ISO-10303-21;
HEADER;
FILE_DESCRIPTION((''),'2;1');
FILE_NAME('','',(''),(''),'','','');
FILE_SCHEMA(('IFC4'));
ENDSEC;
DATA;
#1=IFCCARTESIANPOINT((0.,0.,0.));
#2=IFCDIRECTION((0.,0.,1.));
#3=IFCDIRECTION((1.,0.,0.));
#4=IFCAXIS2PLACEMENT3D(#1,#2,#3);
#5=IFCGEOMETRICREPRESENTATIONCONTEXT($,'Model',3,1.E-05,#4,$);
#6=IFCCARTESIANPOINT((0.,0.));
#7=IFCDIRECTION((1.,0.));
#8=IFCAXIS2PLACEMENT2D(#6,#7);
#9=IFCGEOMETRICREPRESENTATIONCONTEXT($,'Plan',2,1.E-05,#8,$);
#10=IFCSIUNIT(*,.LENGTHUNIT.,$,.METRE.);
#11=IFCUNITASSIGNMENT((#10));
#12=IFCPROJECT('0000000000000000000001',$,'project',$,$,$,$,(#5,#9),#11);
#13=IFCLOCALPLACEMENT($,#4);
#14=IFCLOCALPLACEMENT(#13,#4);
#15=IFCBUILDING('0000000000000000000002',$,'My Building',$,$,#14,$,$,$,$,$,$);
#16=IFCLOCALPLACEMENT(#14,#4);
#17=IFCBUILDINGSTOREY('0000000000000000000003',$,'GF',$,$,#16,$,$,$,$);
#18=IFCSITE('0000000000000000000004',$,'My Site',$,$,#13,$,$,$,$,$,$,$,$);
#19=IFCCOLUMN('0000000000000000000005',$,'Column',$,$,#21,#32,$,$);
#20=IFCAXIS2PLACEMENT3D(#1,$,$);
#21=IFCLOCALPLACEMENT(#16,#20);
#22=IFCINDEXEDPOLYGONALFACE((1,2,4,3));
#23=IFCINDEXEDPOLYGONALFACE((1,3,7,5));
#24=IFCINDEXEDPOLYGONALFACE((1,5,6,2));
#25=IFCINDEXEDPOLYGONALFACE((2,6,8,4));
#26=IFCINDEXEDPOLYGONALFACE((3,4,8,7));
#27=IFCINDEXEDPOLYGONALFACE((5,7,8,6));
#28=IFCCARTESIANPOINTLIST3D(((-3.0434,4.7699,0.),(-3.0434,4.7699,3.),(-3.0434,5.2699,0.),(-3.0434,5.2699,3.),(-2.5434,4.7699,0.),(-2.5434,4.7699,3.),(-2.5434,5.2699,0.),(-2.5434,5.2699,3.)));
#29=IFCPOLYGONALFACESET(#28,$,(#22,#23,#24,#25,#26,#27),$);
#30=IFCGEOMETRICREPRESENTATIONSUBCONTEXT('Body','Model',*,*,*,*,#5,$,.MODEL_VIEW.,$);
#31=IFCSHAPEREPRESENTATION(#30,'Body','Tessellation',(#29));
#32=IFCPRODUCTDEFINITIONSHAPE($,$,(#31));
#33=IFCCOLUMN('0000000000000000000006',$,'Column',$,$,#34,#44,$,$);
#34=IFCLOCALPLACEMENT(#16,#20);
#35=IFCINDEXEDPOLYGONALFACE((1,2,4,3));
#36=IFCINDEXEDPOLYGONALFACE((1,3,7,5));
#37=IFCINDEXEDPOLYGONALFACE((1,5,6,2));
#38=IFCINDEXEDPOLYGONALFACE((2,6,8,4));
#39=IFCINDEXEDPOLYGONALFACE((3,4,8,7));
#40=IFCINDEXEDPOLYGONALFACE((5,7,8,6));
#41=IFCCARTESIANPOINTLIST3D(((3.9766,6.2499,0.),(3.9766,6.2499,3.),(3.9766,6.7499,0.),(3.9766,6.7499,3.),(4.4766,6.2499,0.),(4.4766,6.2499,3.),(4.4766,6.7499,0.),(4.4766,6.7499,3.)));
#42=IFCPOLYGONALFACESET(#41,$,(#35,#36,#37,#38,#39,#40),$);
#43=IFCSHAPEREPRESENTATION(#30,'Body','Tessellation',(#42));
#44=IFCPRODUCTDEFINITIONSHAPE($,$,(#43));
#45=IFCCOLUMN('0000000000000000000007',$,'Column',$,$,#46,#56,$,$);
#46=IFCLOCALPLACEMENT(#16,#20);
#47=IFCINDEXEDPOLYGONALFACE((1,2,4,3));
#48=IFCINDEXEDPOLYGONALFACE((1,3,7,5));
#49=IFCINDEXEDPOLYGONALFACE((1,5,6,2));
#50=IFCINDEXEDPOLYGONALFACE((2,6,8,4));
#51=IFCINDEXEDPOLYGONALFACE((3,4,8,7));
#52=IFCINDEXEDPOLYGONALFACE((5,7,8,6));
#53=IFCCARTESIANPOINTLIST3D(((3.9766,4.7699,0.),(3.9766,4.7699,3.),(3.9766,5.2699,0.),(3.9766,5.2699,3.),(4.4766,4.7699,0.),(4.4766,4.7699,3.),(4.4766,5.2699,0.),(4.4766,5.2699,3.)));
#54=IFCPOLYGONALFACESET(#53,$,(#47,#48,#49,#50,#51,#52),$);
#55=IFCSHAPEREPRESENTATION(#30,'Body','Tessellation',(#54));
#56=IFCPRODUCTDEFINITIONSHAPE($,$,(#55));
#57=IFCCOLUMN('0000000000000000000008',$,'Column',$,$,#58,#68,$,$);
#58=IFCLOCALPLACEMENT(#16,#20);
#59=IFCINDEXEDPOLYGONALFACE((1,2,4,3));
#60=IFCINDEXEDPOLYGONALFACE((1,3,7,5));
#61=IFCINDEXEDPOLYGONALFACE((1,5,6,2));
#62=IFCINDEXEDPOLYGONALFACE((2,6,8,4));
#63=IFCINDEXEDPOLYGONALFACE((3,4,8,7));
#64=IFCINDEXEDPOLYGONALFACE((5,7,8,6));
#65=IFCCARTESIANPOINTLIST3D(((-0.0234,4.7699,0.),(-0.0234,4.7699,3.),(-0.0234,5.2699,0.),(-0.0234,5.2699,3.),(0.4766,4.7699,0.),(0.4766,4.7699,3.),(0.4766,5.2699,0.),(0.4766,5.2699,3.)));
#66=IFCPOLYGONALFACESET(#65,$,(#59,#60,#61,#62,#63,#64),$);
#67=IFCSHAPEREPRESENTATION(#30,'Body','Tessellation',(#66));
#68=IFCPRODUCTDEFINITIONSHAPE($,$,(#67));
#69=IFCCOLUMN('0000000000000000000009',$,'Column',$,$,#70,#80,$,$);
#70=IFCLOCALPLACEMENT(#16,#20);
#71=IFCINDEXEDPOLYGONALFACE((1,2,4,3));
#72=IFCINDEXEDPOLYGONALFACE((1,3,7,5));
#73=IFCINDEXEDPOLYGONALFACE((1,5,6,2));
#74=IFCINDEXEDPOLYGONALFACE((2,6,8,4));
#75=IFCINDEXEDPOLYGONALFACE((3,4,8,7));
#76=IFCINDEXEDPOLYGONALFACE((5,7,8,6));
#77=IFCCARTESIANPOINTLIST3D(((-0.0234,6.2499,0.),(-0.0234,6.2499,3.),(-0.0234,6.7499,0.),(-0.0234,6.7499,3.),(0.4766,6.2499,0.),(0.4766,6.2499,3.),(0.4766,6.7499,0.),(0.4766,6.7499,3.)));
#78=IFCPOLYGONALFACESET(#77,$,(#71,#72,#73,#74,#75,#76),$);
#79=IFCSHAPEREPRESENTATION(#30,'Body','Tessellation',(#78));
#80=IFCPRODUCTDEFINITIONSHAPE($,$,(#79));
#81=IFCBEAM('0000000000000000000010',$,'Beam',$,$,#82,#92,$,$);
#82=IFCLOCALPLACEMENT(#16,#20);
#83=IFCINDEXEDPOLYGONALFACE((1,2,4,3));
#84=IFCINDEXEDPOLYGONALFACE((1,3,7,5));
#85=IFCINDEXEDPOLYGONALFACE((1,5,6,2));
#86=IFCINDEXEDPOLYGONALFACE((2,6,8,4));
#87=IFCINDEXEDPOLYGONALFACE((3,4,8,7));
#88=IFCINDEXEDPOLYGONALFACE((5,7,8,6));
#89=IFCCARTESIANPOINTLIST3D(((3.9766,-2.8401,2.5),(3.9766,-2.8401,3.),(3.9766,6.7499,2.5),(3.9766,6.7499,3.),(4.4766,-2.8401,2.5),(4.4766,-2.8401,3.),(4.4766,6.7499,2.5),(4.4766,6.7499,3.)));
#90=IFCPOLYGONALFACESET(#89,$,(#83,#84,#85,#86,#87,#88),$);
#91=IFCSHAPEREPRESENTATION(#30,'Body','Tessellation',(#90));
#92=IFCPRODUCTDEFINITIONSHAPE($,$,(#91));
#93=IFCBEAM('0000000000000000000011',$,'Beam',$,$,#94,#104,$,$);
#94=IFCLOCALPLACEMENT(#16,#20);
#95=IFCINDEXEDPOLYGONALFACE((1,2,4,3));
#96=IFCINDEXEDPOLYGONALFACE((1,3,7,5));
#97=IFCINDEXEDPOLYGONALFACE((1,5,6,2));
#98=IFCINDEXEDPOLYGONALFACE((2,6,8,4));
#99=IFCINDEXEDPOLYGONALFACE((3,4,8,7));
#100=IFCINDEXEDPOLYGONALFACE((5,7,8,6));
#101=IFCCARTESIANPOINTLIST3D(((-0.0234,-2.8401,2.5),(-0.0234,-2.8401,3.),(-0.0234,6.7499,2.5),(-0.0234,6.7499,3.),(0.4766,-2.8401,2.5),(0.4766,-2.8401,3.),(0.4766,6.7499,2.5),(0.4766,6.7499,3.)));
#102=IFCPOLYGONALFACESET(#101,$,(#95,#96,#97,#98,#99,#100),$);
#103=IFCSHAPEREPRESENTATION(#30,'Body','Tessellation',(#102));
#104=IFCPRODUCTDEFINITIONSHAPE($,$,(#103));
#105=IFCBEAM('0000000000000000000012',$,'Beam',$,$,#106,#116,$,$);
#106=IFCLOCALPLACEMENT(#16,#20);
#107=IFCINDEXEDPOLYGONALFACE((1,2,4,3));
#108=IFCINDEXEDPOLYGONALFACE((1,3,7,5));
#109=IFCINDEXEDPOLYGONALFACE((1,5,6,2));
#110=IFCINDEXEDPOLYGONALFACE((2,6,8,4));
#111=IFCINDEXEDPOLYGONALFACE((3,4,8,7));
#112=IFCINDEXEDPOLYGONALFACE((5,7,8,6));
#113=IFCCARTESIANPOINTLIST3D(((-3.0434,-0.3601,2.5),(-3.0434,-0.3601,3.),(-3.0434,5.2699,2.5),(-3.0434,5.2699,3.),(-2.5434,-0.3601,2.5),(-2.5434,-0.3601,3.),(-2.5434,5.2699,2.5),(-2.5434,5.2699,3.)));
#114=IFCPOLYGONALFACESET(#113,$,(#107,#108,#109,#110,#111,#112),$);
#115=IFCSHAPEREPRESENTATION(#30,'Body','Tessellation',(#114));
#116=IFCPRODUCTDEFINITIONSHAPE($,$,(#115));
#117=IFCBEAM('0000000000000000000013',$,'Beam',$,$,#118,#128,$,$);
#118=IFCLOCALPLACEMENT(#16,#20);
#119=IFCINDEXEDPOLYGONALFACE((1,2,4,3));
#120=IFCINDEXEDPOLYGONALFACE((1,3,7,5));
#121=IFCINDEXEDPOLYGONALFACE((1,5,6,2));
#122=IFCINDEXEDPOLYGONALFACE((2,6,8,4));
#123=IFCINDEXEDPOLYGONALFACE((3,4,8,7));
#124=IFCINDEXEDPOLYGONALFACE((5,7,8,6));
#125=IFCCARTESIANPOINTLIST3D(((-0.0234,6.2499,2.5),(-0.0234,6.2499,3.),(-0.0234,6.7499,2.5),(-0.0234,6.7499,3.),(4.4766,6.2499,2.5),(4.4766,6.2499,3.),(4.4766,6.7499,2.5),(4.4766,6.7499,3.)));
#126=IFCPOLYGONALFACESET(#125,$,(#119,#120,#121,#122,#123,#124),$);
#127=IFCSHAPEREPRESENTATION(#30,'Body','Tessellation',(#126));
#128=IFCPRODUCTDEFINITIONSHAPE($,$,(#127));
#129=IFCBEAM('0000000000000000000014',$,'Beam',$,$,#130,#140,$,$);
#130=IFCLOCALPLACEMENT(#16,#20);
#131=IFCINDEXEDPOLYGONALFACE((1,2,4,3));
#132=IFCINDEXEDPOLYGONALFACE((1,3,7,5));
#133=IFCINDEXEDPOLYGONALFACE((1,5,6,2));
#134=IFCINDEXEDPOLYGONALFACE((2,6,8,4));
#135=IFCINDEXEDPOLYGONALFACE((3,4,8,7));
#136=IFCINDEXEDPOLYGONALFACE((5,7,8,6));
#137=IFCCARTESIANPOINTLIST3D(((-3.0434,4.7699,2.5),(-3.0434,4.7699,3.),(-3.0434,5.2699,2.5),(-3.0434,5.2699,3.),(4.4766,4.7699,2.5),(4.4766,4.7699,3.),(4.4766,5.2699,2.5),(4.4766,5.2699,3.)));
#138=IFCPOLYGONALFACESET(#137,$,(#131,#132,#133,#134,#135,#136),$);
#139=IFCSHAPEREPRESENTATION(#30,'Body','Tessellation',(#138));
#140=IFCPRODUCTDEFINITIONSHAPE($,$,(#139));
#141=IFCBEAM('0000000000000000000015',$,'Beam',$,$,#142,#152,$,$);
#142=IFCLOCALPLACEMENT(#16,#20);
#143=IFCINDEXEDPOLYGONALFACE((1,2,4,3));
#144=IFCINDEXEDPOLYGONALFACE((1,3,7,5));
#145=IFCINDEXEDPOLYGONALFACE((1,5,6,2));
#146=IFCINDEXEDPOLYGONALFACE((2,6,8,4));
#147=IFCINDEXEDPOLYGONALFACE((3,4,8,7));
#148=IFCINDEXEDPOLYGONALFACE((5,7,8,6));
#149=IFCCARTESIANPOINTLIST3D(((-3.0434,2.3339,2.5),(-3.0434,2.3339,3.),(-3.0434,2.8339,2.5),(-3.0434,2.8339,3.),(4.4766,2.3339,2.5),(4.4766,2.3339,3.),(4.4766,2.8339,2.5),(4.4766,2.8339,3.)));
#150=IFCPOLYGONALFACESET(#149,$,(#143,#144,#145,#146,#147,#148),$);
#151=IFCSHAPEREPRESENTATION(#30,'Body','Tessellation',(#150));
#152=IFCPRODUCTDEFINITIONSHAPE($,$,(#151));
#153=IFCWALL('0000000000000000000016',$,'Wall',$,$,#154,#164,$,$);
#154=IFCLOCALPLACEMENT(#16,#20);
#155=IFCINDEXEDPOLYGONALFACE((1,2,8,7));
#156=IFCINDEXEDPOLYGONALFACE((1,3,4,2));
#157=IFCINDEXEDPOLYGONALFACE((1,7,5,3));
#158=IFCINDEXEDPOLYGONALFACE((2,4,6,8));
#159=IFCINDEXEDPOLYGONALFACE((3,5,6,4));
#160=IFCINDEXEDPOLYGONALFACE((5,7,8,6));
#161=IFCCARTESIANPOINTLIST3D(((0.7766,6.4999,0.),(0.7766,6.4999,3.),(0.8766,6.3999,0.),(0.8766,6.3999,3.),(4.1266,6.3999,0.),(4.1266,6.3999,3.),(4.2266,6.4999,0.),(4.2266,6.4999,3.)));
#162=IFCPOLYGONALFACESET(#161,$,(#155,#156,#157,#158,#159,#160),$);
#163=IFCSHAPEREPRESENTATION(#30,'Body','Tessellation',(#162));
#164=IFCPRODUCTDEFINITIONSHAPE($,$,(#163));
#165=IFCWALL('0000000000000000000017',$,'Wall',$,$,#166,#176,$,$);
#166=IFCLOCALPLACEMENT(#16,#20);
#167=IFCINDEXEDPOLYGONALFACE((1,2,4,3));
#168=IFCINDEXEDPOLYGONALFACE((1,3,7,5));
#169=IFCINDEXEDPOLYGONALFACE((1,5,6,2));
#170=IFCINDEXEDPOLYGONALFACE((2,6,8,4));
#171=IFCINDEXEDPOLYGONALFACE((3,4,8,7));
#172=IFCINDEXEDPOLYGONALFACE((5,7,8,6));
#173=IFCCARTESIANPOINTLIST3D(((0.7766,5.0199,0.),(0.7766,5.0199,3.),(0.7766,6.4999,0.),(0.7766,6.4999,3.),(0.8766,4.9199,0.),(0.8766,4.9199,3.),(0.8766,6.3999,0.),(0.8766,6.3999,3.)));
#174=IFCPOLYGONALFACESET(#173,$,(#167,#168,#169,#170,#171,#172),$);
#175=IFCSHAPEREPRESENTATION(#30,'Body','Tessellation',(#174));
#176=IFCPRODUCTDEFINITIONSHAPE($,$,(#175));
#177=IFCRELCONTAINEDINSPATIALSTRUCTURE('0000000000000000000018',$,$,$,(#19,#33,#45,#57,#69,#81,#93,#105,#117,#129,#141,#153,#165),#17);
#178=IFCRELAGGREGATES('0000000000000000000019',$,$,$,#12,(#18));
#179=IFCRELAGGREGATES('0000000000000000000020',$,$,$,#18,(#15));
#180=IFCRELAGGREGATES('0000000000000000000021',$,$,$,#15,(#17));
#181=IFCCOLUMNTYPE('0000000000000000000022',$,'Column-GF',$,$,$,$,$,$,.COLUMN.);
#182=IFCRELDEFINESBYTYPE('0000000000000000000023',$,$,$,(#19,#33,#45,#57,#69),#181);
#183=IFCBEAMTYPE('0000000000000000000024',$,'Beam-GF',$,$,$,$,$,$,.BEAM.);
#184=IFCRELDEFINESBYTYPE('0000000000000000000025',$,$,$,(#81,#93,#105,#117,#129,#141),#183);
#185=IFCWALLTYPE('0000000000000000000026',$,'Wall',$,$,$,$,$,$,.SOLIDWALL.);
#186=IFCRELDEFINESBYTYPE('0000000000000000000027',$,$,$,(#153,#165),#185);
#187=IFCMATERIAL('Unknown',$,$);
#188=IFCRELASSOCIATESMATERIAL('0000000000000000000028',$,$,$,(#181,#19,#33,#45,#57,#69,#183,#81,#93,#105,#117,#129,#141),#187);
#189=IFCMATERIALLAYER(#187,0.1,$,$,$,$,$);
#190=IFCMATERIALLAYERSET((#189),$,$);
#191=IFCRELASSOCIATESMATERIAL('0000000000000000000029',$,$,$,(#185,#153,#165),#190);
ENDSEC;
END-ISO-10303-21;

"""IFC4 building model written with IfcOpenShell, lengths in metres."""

from ifc_helpers import new_model, si_unit, frame, origin_with_axes, origin_2d_with_axis, place, context, subcontext, project, spatial, line, indexed_curve, rectangle, outline, extrude, material, layer, layer_set, layer_usage, material_profile, profile_set, profile_usage, type_object, element, save


model = new_model("IFC4")

# Units and contexts
model_context = context("Model", 3, precision=1e-05, world=origin_with_axes())
plan_context = context("Plan", 2, precision=1e-05, world=origin_2d_with_axis())
body_context_1 = subcontext(model_context, "Body", "Model", "MODEL_VIEW")
ifc_project = project(units=[si_unit("LENGTHUNIT", "METRE")], contexts=[model_context, plan_context])

# Site, building, storey
site_placement = place(None, origin_with_axes())
site = spatial("IfcSite", under=ifc_project, at=site_placement, Name="My Site")
building_placement = place(site_placement, origin_with_axes())
building = spatial("IfcBuilding", under=site, at=building_placement, Name="My Building")
storey_placement = place(building_placement, origin_with_axes())
storey = spatial("IfcBuildingStorey", under=building, at=storey_placement, Name="GF")

# Columns
ifc_material_1 = material(Name="Unknown")
ifc_material_profile_1 = material_profile(ifc_material_1, rectangle(XDim=0.5, YDim=0.5))
ifc_profile_set_1 = profile_set([ifc_material_profile_1])
ifc_profile_usage_1 = profile_usage(ifc_profile_set_1, cardinal=5)
column_type = type_object("IfcColumnType", Name="Column-GF", PredefinedType="COLUMN", material=ifc_profile_set_1)
column_1_placement = place(storey_placement, frame((-2.7934, 5.0199, 0.0), z_axis=(0.0, 0.0, 1.0), x_axis=(1.0, 0.0, 0.0)))
element("IfcColumn", 1, at=column_1_placement, inside=storey, type_object=column_type, material=ifc_profile_usage_1, Name="Column", context=body_context_1, shape_type="SweptSolid", body=[
    extrude(rectangle(XDim=0.5, YDim=0.5), origin_with_axes(), (0.0, 0.0, 1.0), 3.0),
])
ifc_profile_usage_2 = profile_usage(ifc_profile_set_1, cardinal=5)
column_2_placement = place(storey_placement, frame((4.2266, 6.4999, 0.0), z_axis=(0.0, 0.0, 1.0), x_axis=(1.0, 0.0, 0.0)))
element("IfcColumn", 2, at=column_2_placement, inside=storey, type_object=column_type, material=ifc_profile_usage_2, Name="Column", context=body_context_1, shape_type="SweptSolid", body=[
    extrude(rectangle(XDim=0.5, YDim=0.5), origin_with_axes(), (0.0, 0.0, 1.0), 3.0),
])
ifc_profile_usage_3 = profile_usage(ifc_profile_set_1, cardinal=5)
column_3_placement = place(storey_placement, frame((4.2266, 5.0199, 0.0), z_axis=(0.0, 0.0, 1.0), x_axis=(1.0, 0.0, 0.0)))
element("IfcColumn", 3, at=column_3_placement, inside=storey, type_object=column_type, material=ifc_profile_usage_3, Name="Column", context=body_context_1, shape_type="SweptSolid", body=[
    extrude(rectangle(XDim=0.5, YDim=0.5), origin_with_axes(), (0.0, 0.0, 1.0), 3.0),
])
ifc_profile_usage_4 = profile_usage(ifc_profile_set_1, cardinal=5)
column_4_placement = place(storey_placement, frame((0.2266, 5.0199, 0.0), z_axis=(0.0, 0.0, 1.0), x_axis=(1.0, 0.0, 0.0)))
element("IfcColumn", 4, at=column_4_placement, inside=storey, type_object=column_type, material=ifc_profile_usage_4, Name="Column", context=body_context_1, shape_type="SweptSolid", body=[
    extrude(rectangle(XDim=0.5, YDim=0.5), origin_with_axes(), (0.0, 0.0, 1.0), 3.0),
])
ifc_profile_usage_5 = profile_usage(ifc_profile_set_1, cardinal=5)
column_5_placement = place(storey_placement, frame((0.2266, 6.4999, 0.0), z_axis=(0.0, 0.0, 1.0), x_axis=(1.0, 0.0, 0.0)))
element("IfcColumn", 5, at=column_5_placement, inside=storey, type_object=column_type, material=ifc_profile_usage_5, Name="Column", context=body_context_1, shape_type="SweptSolid", body=[
    extrude(rectangle(XDim=0.5, YDim=0.5), origin_with_axes(), (0.0, 0.0, 1.0), 3.0),
])

# Beams
ifc_material_profile_2 = material_profile(ifc_material_1, rectangle(XDim=0.5, YDim=0.5))
ifc_profile_set_2 = profile_set([ifc_material_profile_2])
ifc_profile_usage_6 = profile_usage(ifc_profile_set_2, cardinal=7)
beam_type = type_object("IfcBeamType", Name="Beam-GF", PredefinedType="BEAM", material=ifc_profile_set_2)
beam_1_placement = place(storey_placement, frame((4.4766, 6.7499, 3.0), z_axis=(0.0, -1.0, 0.0), x_axis=(1.0, 0.0, 0.0)))
element("IfcBeam", 6, at=beam_1_placement, inside=storey, type_object=beam_type, material=ifc_profile_usage_6, Name="Beam", context=body_context_1, shape_type="SweptSolid", body=[
    extrude(rectangle(XDim=0.5, YDim=0.5), frame((-0.25, -0.25, 0.0), z_axis=(0.0, 0.0, 1.0), x_axis=(1.0, 0.0, 0.0)), (0.0, 0.0, 1.0), 9.59),
])
ifc_profile_usage_7 = profile_usage(ifc_profile_set_2, cardinal=7)
beam_2_placement = place(storey_placement, frame((0.4766, 6.7499, 3.0), z_axis=(0.0, -1.0, 0.0), x_axis=(1.0, 0.0, 0.0)))
element("IfcBeam", 7, at=beam_2_placement, inside=storey, type_object=beam_type, material=ifc_profile_usage_7, Name="Beam", context=body_context_1, shape_type="SweptSolid", body=[
    extrude(rectangle(XDim=0.5, YDim=0.5), frame((-0.25, -0.25, 0.0), z_axis=(0.0, 0.0, 1.0), x_axis=(1.0, 0.0, 0.0)), (0.0, 0.0, 1.0), 9.59),
])
ifc_profile_usage_8 = profile_usage(ifc_profile_set_2, cardinal=7)
beam_3_placement = place(storey_placement, frame((-2.5434, 5.2699, 3.0), z_axis=(0.0, -1.0, 0.0), x_axis=(1.0, 0.0, 0.0)))
element("IfcBeam", 8, at=beam_3_placement, inside=storey, type_object=beam_type, material=ifc_profile_usage_8, Name="Beam", context=body_context_1, shape_type="SweptSolid", body=[
    extrude(rectangle(XDim=0.5, YDim=0.5), frame((-0.25, -0.25, 0.0), z_axis=(0.0, 0.0, 1.0), x_axis=(1.0, 0.0, 0.0)), (0.0, 0.0, 1.0), 5.63),
])
ifc_profile_usage_9 = profile_usage(ifc_profile_set_2, cardinal=7)
beam_4_placement = place(storey_placement, frame((-0.0234, 6.7499, 3.0), z_axis=(1.0, -0.000001, 0.000001), x_axis=(0.000001, 1.0, 0.0)))
element("IfcBeam", 9, at=beam_4_placement, inside=storey, type_object=beam_type, material=ifc_profile_usage_9, Name="Beam", context=body_context_1, shape_type="SweptSolid", body=[
    extrude(rectangle(XDim=0.5, YDim=0.5), frame((-0.25, -0.25, 0.0), z_axis=(0.0, 0.0, 1.0), x_axis=(1.0, 0.0, 0.0)), (0.0, 0.0, 1.0), 4.5),
])
ifc_profile_usage_10 = profile_usage(ifc_profile_set_2, cardinal=7)
beam_5_placement = place(storey_placement, frame((-3.0434, 5.2699, 3.0), z_axis=(1.0, 0.0, 0.0), x_axis=(0.0, 1.0, 0.0)))
element("IfcBeam", 10, at=beam_5_placement, inside=storey, type_object=beam_type, material=ifc_profile_usage_10, Name="Beam", context=body_context_1, shape_type="SweptSolid", body=[
    extrude(rectangle(XDim=0.5, YDim=0.5), frame((-0.25, -0.25, 0.0), z_axis=(0.0, 0.0, 1.0), x_axis=(1.0, 0.0, 0.0)), (0.0, 0.0, 1.0), 7.52),
])
ifc_profile_usage_11 = profile_usage(ifc_profile_set_2, cardinal=7)
beam_6_placement = place(storey_placement, frame((-3.0434, 2.8339, 3.0), z_axis=(1.0, 0.0, 0.0), x_axis=(0.0, 1.0, 0.0)))
element("IfcBeam", 11, at=beam_6_placement, inside=storey, type_object=beam_type, material=ifc_profile_usage_11, Name="Beam", context=body_context_1, shape_type="SweptSolid", body=[
    extrude(rectangle(XDim=0.5, YDim=0.5), frame((-0.25, -0.25, 0.0), z_axis=(0.0, 0.0, 1.0), x_axis=(1.0, 0.0, 0.0)), (0.0, 0.0, 1.0), 7.52),
])

# Walls
ifc_layer_1 = layer(ifc_material_1, 0.1)
ifc_layer_set_1 = layer_set([ifc_layer_1])
ifc_layer_usage_1 = layer_usage(ifc_layer_set_1, "AXIS2", "POSITIVE", 0.0)
wall_type = type_object("IfcWallType", Name="Wall", PredefinedType="SOLIDWALL", material=ifc_layer_set_1)
wall_1_placement = place(storey_placement, frame((4.2266, 6.4999, 0.0), z_axis=(0.0, 0.0, 1.0), x_axis=(-1.0, 0.0, 0.0)))
element("IfcWall", 12, at=wall_1_placement, inside=storey, type_object=wall_type, material=ifc_layer_usage_1, Name="Wall", context=body_context_1, shape_type="SweptSolid", body=[
    extrude(outline(indexed_curve([(0.0, 0.0), (0.1, 0.1), (3.35, 0.1), (3.45, 0.0)], segments=[line(1, 2, 3, 4, 1)])), origin_with_axes(), (0.0, 0.0, 1.0), 3.0),
])
ifc_layer_usage_2 = layer_usage(ifc_layer_set_1, "AXIS2", "POSITIVE", 0.0)
wall_2_placement = place(storey_placement, frame((0.7766, 6.4999, 0.0), z_axis=(0.0, 0.0, 1.0), x_axis=(0.0, -1.0, 0.0)))
element("IfcWall", 13, at=wall_2_placement, inside=storey, type_object=wall_type, material=ifc_layer_usage_2, Name="Wall", context=body_context_1, shape_type="SweptSolid", body=[
    extrude(outline(indexed_curve([(0.0, 0.0), (0.1, 0.1), (1.58, 0.1), (1.48, 0.0)], segments=[line(1, 2, 3, 4, 1)])), origin_with_axes(), (0.0, 0.0, 1.0), 3.0),
])

save(model, "model.ifc")
